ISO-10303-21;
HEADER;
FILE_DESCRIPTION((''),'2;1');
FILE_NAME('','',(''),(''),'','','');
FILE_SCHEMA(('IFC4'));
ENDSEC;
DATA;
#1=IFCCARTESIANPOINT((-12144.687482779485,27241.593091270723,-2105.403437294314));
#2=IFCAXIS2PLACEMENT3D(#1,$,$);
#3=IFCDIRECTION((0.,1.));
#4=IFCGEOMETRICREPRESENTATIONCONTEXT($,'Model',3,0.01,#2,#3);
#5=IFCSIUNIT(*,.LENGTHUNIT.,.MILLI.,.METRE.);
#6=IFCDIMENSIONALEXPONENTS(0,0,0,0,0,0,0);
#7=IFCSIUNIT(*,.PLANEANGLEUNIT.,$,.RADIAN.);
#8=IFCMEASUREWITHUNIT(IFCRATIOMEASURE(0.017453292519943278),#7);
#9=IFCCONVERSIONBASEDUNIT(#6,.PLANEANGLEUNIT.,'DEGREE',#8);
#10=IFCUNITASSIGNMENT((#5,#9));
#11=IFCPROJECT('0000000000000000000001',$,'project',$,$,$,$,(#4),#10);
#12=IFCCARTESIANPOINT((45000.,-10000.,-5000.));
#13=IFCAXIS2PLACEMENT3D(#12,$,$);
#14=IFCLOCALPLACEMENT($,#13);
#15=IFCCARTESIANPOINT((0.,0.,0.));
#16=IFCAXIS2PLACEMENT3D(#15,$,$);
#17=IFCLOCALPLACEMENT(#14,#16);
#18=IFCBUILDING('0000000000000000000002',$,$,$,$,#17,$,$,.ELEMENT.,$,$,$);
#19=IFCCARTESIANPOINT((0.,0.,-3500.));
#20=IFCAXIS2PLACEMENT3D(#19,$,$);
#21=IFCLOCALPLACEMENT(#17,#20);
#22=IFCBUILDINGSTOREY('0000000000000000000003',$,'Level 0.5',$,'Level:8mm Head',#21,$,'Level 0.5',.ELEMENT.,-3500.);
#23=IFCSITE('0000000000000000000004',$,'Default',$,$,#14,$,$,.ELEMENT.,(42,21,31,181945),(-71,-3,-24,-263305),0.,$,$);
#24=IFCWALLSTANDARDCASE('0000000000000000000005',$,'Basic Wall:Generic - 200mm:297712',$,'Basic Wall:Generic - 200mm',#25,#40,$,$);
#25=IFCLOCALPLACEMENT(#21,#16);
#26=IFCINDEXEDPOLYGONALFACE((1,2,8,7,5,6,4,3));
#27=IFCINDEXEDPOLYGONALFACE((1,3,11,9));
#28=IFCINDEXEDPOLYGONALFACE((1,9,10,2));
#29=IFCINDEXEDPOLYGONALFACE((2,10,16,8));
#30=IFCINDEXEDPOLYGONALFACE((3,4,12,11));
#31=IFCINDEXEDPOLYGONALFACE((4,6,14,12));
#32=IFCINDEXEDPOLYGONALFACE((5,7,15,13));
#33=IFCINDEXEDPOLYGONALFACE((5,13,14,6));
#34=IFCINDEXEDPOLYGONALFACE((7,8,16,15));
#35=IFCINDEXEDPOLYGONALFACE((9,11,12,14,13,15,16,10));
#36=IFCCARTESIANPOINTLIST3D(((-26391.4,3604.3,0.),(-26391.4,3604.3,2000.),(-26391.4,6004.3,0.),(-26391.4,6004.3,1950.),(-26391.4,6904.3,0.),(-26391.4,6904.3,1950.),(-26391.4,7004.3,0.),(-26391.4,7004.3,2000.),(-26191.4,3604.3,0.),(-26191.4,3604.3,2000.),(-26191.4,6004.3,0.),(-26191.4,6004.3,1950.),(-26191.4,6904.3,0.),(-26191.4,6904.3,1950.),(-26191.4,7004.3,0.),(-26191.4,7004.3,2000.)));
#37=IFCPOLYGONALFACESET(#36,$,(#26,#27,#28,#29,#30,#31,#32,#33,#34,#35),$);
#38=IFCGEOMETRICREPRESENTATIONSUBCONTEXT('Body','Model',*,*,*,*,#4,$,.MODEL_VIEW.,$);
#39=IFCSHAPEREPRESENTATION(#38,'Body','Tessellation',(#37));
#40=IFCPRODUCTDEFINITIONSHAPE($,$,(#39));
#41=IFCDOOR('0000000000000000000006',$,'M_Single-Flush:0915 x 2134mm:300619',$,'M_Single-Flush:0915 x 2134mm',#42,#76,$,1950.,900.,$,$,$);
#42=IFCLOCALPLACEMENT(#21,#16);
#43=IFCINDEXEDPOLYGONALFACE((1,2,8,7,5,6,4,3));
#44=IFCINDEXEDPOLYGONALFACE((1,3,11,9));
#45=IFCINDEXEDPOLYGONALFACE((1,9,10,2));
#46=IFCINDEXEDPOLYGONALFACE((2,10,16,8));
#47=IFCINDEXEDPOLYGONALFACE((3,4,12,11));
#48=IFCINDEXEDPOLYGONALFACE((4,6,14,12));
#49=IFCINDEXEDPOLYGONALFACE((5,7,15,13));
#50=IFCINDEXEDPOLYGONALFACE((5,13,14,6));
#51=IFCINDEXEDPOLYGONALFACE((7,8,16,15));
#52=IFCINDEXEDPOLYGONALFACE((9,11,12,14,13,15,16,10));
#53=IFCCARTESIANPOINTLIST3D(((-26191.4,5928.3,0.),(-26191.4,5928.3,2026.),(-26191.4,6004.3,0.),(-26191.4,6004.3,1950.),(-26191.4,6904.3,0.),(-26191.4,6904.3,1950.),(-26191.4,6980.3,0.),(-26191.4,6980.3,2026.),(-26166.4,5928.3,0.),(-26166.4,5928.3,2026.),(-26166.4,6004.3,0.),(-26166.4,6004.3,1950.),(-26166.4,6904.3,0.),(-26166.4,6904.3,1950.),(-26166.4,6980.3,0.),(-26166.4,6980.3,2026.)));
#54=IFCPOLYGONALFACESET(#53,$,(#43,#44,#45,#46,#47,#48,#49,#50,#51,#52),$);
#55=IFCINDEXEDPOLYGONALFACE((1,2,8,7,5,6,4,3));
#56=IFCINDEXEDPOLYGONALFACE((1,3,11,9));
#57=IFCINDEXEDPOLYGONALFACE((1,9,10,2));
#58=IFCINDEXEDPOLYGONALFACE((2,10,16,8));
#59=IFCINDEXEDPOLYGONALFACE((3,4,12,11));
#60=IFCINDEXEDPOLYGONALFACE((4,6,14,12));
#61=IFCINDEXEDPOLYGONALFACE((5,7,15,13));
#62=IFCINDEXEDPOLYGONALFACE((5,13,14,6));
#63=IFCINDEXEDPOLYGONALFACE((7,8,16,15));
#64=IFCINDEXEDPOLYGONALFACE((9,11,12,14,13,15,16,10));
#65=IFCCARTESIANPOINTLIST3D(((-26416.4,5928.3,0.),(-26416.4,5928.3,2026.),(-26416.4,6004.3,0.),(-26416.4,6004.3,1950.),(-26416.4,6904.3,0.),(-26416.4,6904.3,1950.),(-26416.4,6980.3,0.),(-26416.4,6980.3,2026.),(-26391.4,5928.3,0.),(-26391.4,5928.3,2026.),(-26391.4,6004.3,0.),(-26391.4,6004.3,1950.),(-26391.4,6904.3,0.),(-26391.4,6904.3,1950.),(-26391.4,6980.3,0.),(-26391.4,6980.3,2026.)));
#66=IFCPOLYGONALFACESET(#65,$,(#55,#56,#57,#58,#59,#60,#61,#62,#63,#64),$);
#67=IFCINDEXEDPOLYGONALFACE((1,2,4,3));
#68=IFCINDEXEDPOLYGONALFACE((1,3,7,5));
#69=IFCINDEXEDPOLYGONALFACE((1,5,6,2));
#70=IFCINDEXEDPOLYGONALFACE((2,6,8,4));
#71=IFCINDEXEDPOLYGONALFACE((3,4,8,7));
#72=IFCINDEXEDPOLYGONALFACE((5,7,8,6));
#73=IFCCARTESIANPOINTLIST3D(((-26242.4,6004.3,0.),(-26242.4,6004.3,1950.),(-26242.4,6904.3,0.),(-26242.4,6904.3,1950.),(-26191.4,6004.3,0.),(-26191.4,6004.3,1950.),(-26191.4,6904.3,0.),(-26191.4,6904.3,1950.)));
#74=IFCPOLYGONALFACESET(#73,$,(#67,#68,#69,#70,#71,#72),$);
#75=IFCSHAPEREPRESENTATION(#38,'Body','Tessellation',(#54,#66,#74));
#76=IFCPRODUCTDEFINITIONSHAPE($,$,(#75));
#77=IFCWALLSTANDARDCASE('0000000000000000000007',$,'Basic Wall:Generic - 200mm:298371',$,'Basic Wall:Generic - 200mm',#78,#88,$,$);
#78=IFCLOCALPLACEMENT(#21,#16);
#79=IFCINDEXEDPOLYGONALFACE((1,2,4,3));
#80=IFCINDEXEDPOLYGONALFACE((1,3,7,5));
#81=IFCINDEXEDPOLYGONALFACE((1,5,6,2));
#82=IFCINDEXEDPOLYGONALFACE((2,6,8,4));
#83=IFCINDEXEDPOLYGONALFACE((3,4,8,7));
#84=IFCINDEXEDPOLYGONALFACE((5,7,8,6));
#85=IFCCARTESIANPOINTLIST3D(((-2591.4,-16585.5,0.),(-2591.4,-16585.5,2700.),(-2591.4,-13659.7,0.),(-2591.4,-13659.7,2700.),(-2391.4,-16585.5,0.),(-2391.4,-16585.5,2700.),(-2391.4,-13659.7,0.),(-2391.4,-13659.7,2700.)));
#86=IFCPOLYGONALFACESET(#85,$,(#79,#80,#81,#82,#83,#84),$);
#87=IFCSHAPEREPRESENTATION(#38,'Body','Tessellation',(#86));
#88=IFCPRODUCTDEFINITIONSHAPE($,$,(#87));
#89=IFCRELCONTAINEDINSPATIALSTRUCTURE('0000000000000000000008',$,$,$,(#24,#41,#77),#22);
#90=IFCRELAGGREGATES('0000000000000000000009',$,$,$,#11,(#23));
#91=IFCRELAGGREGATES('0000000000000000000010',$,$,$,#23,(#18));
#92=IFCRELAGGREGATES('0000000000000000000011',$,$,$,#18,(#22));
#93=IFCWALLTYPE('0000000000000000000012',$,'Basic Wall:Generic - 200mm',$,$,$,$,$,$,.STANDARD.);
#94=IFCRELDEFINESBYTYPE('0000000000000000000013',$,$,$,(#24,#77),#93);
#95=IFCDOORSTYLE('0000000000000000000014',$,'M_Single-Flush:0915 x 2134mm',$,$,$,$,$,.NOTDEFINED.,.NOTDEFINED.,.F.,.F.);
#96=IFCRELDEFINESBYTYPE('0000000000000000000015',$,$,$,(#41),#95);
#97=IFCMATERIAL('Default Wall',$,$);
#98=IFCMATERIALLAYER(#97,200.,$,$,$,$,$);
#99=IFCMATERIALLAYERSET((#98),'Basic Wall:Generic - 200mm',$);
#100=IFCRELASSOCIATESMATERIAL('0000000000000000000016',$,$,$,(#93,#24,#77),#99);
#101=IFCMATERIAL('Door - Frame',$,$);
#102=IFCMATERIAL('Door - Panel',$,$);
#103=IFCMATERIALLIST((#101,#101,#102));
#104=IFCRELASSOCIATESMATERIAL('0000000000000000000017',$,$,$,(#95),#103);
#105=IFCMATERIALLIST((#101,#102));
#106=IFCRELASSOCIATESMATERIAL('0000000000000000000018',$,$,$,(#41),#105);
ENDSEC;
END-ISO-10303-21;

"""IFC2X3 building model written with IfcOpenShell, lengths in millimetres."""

from ifc_helpers import new_model, entity, si_unit, converted_unit, direction, frame, frame_2d, origin, place, context, subcontext, project, spatial, polyline, rectangle, outline, extrude, clip, bounded_halfspace, source, transform, mapped, material, material_list, layer, layer_set, layer_usage, type_object, type_shapes, element, fill, save


model = new_model("IFC2X3")

# Units and contexts
model_context = context("Model", 3, precision=0.01, world=frame((-12144.687482779485, 27241.593091270723, -2105.403437294314)), true_north=direction((0.0, 1.0)))
body_context = subcontext(model_context, "Body", "Model", "MODEL_VIEW")
ifc_project = project(units=[si_unit("LENGTHUNIT", "METRE", prefix="MILLI"), converted_unit("PLANEANGLEUNIT", "DEGREE", entity("IfcRatioMeasure", 0.017453292519943278), si_unit("PLANEANGLEUNIT", "RADIAN"), dimensions=[0, 0, 0, 0, 0, 0, 0])], contexts=[model_context])

# Site, building, storey
site_placement = place(None, frame((45000.0, -10000.0, -5000.0)))
site = spatial("IfcSite", under=ifc_project, at=site_placement, Name="Default", CompositionType="ELEMENT", RefLatitude=(42, 21, 31, 181945), RefLongitude=(-71, -3, -24, -263305), RefElevation=0.0)
building_placement = place(site_placement, origin())
building = spatial("IfcBuilding", under=site, at=building_placement, CompositionType="ELEMENT")
storey_placement = place(building_placement, frame((0.0, 0.0, -3500.0)))
storey = spatial("IfcBuildingStorey", under=building, at=storey_placement, Name="Level 0.5", ObjectType="Level:8mm Head", LongName="Level 0.5", CompositionType="ELEMENT", Elevation=-3500.0)

# Shared definitions
ifc_material_1 = material(Name="Default Wall")
ifc_layer_1 = layer(ifc_material_1, 200.0)
ifc_layer_set_1 = layer_set([ifc_layer_1], Name="Basic Wall:Generic - 200mm")
wall_type_1 = type_object("IfcWallType", Name="Basic Wall:Generic - 200mm", PredefinedType="STANDARD", material=ifc_layer_set_1)

# Wall, opening, door
ifc_layer_usage_1 = layer_usage(ifc_layer_set_1, "AXIS2", "NEGATIVE", 100.0)
wall_1_placement = place(storey_placement, frame((-26291.4, 3604.3, 0.0), z_axis=(0.0, 0.0, 1.0), x_axis=(0.0, 1.0, 0.0)))
wall_1 = element("IfcWallStandardCase", 1, at=wall_1_placement, inside=storey, type_object=wall_type_1, material=ifc_layer_usage_1, Name="Basic Wall:Generic - 200mm:297712", ObjectType="Basic Wall:Generic - 200mm", context=body_context, shape_type="Clipping", body=[
    clip(extrude(rectangle(XDim=3400.0, YDim=200.0, at=frame_2d((1700.0, 0.0), x_axis=(1.0, 0.0))), origin(), (0.0, 0.0, 1.0), 2000.0), bounded_halfspace(frame((0.0, -100.0, 2000.0), z_axis=(0.0, 0.0, -1.0), x_axis=(0.0, -1.0, 0.0)), True, frame((0.0, -100.0, 2000.0)), polyline([(0.0, 0.0), (1036320.0, 0.0), (1036320.0, 60960.0), (0.0, 60960.0), (0.0, 0.0)]))),
])
opening_1_placement = place(wall_1_placement, frame((3300.0, 100.0, 0.0)))
opening_1 = element("IfcOpeningElement", 2, at=opening_1_placement, cuts=wall_1, ObjectType="Opening", context=body_context, shape_type="SweptSolid", body=[
    extrude(rectangle(XDim=900.0, YDim=1950.0, at=frame_2d((975.0, 450.0), x_axis=(0.0, -1.0))), frame((0.0, 0.0, 0.0), z_axis=(0.0, -1.0, 0.0), x_axis=(0.0, 0.0, 1.0)), (0.0, 0.0, 1.0), 200.0),
])
ifc_material_2 = material(Name="Door - Frame")
ifc_material_3 = material(Name="Door - Panel")
ifc_material_list_1 = material_list([ifc_material_2, ifc_material_3])
ifc_material_list_2 = material_list([ifc_material_2, ifc_material_2, ifc_material_3])
door_style_1 = type_object("IfcDoorStyle", Name="M_Single-Flush:0915 x 2134mm", ConstructionType="NOTDEFINED", OperationType="NOTDEFINED", ParameterTakesPrecedence=False, Sizeable=False, material=ifc_material_list_2)
shared_shape_1 = source(origin(), body_context, "Body", "SweptSolid", [
    extrude(outline(polyline([(-526.0, -1032.0), (526.0, -1032.0), (526.0, 994.0), (450.0, 994.0), (450.0, -956.0), (-450.0, -956.0), (-450.0, 994.0), (-526.0, 994.0), (-526.0, -1032.0)])), frame((450.0, 225.0, 994.0), z_axis=(0.0, -1.0, 0.0), x_axis=(-1.0, 0.0, 0.0)), (0.0, 0.0, 1.0), 25.0),
    extrude(outline(polyline([(-1032.0, -526.0), (994.0, -526.0), (994.0, -450.0), (-956.0, -450.0), (-956.0, 450.0), (994.0, 450.0), (994.0, 526.0), (-1032.0, 526.0), (-1032.0, -526.0)])), frame((450.0, 0.0, 994.0), z_axis=(0.0, -1.0, 0.0), x_axis=(0.0, 0.0, -1.0)), (0.0, 0.0, 1.0), 25.0),
    extrude(rectangle(XDim=900.0, YDim=51.0, at=frame_2d((0.0, 0.0), x_axis=(1.0, 0.0))), frame((450.0, 174.5, 0.0)), (0.0, 0.0, 1.0), 1950.0),
])
type_shapes(door_style_1, [shared_shape_1])
door_1_placement = place(opening_1_placement, frame((0.0, 0.0, 0.0), z_axis=(0.0, 0.0, 1.0), x_axis=(-1.0, 0.0, 0.0)))
door_1 = element("IfcDoor", 3, at=door_1_placement, inside=storey, type_object=door_style_1, material=ifc_material_list_1, Name="M_Single-Flush:0915 x 2134mm:300619", ObjectType="M_Single-Flush:0915 x 2134mm", OverallHeight=1950.0, OverallWidth=900.0, context=body_context, shape_type="MappedRepresentation", body=[
    mapped(shared_shape_1, transform((0.0, 0.0, 0.0), scale=1.0)),
])
fill(opening_1, door_1)

# Wall
ifc_layer_usage_2 = layer_usage(ifc_layer_set_1, "AXIS2", "NEGATIVE", 100.0)
wall_2_placement = place(storey_placement, frame((-2491.4, -16585.5, 0.0), z_axis=(0.0, 0.0, 1.0), x_axis=(0.0, 1.0, 0.0)))
element("IfcWallStandardCase", 4, at=wall_2_placement, inside=storey, type_object=wall_type_1, material=ifc_layer_usage_2, Name="Basic Wall:Generic - 200mm:298371", ObjectType="Basic Wall:Generic - 200mm", context=body_context, shape_type="SweptSolid", body=[
    extrude(rectangle(XDim=2925.8, YDim=200.0, at=frame_2d((1462.9, 0.0), x_axis=(-1.0, 0.0))), origin(), (0.0, 0.0, 1.0), 2700.0),
])

save(model, "model.ifc")
